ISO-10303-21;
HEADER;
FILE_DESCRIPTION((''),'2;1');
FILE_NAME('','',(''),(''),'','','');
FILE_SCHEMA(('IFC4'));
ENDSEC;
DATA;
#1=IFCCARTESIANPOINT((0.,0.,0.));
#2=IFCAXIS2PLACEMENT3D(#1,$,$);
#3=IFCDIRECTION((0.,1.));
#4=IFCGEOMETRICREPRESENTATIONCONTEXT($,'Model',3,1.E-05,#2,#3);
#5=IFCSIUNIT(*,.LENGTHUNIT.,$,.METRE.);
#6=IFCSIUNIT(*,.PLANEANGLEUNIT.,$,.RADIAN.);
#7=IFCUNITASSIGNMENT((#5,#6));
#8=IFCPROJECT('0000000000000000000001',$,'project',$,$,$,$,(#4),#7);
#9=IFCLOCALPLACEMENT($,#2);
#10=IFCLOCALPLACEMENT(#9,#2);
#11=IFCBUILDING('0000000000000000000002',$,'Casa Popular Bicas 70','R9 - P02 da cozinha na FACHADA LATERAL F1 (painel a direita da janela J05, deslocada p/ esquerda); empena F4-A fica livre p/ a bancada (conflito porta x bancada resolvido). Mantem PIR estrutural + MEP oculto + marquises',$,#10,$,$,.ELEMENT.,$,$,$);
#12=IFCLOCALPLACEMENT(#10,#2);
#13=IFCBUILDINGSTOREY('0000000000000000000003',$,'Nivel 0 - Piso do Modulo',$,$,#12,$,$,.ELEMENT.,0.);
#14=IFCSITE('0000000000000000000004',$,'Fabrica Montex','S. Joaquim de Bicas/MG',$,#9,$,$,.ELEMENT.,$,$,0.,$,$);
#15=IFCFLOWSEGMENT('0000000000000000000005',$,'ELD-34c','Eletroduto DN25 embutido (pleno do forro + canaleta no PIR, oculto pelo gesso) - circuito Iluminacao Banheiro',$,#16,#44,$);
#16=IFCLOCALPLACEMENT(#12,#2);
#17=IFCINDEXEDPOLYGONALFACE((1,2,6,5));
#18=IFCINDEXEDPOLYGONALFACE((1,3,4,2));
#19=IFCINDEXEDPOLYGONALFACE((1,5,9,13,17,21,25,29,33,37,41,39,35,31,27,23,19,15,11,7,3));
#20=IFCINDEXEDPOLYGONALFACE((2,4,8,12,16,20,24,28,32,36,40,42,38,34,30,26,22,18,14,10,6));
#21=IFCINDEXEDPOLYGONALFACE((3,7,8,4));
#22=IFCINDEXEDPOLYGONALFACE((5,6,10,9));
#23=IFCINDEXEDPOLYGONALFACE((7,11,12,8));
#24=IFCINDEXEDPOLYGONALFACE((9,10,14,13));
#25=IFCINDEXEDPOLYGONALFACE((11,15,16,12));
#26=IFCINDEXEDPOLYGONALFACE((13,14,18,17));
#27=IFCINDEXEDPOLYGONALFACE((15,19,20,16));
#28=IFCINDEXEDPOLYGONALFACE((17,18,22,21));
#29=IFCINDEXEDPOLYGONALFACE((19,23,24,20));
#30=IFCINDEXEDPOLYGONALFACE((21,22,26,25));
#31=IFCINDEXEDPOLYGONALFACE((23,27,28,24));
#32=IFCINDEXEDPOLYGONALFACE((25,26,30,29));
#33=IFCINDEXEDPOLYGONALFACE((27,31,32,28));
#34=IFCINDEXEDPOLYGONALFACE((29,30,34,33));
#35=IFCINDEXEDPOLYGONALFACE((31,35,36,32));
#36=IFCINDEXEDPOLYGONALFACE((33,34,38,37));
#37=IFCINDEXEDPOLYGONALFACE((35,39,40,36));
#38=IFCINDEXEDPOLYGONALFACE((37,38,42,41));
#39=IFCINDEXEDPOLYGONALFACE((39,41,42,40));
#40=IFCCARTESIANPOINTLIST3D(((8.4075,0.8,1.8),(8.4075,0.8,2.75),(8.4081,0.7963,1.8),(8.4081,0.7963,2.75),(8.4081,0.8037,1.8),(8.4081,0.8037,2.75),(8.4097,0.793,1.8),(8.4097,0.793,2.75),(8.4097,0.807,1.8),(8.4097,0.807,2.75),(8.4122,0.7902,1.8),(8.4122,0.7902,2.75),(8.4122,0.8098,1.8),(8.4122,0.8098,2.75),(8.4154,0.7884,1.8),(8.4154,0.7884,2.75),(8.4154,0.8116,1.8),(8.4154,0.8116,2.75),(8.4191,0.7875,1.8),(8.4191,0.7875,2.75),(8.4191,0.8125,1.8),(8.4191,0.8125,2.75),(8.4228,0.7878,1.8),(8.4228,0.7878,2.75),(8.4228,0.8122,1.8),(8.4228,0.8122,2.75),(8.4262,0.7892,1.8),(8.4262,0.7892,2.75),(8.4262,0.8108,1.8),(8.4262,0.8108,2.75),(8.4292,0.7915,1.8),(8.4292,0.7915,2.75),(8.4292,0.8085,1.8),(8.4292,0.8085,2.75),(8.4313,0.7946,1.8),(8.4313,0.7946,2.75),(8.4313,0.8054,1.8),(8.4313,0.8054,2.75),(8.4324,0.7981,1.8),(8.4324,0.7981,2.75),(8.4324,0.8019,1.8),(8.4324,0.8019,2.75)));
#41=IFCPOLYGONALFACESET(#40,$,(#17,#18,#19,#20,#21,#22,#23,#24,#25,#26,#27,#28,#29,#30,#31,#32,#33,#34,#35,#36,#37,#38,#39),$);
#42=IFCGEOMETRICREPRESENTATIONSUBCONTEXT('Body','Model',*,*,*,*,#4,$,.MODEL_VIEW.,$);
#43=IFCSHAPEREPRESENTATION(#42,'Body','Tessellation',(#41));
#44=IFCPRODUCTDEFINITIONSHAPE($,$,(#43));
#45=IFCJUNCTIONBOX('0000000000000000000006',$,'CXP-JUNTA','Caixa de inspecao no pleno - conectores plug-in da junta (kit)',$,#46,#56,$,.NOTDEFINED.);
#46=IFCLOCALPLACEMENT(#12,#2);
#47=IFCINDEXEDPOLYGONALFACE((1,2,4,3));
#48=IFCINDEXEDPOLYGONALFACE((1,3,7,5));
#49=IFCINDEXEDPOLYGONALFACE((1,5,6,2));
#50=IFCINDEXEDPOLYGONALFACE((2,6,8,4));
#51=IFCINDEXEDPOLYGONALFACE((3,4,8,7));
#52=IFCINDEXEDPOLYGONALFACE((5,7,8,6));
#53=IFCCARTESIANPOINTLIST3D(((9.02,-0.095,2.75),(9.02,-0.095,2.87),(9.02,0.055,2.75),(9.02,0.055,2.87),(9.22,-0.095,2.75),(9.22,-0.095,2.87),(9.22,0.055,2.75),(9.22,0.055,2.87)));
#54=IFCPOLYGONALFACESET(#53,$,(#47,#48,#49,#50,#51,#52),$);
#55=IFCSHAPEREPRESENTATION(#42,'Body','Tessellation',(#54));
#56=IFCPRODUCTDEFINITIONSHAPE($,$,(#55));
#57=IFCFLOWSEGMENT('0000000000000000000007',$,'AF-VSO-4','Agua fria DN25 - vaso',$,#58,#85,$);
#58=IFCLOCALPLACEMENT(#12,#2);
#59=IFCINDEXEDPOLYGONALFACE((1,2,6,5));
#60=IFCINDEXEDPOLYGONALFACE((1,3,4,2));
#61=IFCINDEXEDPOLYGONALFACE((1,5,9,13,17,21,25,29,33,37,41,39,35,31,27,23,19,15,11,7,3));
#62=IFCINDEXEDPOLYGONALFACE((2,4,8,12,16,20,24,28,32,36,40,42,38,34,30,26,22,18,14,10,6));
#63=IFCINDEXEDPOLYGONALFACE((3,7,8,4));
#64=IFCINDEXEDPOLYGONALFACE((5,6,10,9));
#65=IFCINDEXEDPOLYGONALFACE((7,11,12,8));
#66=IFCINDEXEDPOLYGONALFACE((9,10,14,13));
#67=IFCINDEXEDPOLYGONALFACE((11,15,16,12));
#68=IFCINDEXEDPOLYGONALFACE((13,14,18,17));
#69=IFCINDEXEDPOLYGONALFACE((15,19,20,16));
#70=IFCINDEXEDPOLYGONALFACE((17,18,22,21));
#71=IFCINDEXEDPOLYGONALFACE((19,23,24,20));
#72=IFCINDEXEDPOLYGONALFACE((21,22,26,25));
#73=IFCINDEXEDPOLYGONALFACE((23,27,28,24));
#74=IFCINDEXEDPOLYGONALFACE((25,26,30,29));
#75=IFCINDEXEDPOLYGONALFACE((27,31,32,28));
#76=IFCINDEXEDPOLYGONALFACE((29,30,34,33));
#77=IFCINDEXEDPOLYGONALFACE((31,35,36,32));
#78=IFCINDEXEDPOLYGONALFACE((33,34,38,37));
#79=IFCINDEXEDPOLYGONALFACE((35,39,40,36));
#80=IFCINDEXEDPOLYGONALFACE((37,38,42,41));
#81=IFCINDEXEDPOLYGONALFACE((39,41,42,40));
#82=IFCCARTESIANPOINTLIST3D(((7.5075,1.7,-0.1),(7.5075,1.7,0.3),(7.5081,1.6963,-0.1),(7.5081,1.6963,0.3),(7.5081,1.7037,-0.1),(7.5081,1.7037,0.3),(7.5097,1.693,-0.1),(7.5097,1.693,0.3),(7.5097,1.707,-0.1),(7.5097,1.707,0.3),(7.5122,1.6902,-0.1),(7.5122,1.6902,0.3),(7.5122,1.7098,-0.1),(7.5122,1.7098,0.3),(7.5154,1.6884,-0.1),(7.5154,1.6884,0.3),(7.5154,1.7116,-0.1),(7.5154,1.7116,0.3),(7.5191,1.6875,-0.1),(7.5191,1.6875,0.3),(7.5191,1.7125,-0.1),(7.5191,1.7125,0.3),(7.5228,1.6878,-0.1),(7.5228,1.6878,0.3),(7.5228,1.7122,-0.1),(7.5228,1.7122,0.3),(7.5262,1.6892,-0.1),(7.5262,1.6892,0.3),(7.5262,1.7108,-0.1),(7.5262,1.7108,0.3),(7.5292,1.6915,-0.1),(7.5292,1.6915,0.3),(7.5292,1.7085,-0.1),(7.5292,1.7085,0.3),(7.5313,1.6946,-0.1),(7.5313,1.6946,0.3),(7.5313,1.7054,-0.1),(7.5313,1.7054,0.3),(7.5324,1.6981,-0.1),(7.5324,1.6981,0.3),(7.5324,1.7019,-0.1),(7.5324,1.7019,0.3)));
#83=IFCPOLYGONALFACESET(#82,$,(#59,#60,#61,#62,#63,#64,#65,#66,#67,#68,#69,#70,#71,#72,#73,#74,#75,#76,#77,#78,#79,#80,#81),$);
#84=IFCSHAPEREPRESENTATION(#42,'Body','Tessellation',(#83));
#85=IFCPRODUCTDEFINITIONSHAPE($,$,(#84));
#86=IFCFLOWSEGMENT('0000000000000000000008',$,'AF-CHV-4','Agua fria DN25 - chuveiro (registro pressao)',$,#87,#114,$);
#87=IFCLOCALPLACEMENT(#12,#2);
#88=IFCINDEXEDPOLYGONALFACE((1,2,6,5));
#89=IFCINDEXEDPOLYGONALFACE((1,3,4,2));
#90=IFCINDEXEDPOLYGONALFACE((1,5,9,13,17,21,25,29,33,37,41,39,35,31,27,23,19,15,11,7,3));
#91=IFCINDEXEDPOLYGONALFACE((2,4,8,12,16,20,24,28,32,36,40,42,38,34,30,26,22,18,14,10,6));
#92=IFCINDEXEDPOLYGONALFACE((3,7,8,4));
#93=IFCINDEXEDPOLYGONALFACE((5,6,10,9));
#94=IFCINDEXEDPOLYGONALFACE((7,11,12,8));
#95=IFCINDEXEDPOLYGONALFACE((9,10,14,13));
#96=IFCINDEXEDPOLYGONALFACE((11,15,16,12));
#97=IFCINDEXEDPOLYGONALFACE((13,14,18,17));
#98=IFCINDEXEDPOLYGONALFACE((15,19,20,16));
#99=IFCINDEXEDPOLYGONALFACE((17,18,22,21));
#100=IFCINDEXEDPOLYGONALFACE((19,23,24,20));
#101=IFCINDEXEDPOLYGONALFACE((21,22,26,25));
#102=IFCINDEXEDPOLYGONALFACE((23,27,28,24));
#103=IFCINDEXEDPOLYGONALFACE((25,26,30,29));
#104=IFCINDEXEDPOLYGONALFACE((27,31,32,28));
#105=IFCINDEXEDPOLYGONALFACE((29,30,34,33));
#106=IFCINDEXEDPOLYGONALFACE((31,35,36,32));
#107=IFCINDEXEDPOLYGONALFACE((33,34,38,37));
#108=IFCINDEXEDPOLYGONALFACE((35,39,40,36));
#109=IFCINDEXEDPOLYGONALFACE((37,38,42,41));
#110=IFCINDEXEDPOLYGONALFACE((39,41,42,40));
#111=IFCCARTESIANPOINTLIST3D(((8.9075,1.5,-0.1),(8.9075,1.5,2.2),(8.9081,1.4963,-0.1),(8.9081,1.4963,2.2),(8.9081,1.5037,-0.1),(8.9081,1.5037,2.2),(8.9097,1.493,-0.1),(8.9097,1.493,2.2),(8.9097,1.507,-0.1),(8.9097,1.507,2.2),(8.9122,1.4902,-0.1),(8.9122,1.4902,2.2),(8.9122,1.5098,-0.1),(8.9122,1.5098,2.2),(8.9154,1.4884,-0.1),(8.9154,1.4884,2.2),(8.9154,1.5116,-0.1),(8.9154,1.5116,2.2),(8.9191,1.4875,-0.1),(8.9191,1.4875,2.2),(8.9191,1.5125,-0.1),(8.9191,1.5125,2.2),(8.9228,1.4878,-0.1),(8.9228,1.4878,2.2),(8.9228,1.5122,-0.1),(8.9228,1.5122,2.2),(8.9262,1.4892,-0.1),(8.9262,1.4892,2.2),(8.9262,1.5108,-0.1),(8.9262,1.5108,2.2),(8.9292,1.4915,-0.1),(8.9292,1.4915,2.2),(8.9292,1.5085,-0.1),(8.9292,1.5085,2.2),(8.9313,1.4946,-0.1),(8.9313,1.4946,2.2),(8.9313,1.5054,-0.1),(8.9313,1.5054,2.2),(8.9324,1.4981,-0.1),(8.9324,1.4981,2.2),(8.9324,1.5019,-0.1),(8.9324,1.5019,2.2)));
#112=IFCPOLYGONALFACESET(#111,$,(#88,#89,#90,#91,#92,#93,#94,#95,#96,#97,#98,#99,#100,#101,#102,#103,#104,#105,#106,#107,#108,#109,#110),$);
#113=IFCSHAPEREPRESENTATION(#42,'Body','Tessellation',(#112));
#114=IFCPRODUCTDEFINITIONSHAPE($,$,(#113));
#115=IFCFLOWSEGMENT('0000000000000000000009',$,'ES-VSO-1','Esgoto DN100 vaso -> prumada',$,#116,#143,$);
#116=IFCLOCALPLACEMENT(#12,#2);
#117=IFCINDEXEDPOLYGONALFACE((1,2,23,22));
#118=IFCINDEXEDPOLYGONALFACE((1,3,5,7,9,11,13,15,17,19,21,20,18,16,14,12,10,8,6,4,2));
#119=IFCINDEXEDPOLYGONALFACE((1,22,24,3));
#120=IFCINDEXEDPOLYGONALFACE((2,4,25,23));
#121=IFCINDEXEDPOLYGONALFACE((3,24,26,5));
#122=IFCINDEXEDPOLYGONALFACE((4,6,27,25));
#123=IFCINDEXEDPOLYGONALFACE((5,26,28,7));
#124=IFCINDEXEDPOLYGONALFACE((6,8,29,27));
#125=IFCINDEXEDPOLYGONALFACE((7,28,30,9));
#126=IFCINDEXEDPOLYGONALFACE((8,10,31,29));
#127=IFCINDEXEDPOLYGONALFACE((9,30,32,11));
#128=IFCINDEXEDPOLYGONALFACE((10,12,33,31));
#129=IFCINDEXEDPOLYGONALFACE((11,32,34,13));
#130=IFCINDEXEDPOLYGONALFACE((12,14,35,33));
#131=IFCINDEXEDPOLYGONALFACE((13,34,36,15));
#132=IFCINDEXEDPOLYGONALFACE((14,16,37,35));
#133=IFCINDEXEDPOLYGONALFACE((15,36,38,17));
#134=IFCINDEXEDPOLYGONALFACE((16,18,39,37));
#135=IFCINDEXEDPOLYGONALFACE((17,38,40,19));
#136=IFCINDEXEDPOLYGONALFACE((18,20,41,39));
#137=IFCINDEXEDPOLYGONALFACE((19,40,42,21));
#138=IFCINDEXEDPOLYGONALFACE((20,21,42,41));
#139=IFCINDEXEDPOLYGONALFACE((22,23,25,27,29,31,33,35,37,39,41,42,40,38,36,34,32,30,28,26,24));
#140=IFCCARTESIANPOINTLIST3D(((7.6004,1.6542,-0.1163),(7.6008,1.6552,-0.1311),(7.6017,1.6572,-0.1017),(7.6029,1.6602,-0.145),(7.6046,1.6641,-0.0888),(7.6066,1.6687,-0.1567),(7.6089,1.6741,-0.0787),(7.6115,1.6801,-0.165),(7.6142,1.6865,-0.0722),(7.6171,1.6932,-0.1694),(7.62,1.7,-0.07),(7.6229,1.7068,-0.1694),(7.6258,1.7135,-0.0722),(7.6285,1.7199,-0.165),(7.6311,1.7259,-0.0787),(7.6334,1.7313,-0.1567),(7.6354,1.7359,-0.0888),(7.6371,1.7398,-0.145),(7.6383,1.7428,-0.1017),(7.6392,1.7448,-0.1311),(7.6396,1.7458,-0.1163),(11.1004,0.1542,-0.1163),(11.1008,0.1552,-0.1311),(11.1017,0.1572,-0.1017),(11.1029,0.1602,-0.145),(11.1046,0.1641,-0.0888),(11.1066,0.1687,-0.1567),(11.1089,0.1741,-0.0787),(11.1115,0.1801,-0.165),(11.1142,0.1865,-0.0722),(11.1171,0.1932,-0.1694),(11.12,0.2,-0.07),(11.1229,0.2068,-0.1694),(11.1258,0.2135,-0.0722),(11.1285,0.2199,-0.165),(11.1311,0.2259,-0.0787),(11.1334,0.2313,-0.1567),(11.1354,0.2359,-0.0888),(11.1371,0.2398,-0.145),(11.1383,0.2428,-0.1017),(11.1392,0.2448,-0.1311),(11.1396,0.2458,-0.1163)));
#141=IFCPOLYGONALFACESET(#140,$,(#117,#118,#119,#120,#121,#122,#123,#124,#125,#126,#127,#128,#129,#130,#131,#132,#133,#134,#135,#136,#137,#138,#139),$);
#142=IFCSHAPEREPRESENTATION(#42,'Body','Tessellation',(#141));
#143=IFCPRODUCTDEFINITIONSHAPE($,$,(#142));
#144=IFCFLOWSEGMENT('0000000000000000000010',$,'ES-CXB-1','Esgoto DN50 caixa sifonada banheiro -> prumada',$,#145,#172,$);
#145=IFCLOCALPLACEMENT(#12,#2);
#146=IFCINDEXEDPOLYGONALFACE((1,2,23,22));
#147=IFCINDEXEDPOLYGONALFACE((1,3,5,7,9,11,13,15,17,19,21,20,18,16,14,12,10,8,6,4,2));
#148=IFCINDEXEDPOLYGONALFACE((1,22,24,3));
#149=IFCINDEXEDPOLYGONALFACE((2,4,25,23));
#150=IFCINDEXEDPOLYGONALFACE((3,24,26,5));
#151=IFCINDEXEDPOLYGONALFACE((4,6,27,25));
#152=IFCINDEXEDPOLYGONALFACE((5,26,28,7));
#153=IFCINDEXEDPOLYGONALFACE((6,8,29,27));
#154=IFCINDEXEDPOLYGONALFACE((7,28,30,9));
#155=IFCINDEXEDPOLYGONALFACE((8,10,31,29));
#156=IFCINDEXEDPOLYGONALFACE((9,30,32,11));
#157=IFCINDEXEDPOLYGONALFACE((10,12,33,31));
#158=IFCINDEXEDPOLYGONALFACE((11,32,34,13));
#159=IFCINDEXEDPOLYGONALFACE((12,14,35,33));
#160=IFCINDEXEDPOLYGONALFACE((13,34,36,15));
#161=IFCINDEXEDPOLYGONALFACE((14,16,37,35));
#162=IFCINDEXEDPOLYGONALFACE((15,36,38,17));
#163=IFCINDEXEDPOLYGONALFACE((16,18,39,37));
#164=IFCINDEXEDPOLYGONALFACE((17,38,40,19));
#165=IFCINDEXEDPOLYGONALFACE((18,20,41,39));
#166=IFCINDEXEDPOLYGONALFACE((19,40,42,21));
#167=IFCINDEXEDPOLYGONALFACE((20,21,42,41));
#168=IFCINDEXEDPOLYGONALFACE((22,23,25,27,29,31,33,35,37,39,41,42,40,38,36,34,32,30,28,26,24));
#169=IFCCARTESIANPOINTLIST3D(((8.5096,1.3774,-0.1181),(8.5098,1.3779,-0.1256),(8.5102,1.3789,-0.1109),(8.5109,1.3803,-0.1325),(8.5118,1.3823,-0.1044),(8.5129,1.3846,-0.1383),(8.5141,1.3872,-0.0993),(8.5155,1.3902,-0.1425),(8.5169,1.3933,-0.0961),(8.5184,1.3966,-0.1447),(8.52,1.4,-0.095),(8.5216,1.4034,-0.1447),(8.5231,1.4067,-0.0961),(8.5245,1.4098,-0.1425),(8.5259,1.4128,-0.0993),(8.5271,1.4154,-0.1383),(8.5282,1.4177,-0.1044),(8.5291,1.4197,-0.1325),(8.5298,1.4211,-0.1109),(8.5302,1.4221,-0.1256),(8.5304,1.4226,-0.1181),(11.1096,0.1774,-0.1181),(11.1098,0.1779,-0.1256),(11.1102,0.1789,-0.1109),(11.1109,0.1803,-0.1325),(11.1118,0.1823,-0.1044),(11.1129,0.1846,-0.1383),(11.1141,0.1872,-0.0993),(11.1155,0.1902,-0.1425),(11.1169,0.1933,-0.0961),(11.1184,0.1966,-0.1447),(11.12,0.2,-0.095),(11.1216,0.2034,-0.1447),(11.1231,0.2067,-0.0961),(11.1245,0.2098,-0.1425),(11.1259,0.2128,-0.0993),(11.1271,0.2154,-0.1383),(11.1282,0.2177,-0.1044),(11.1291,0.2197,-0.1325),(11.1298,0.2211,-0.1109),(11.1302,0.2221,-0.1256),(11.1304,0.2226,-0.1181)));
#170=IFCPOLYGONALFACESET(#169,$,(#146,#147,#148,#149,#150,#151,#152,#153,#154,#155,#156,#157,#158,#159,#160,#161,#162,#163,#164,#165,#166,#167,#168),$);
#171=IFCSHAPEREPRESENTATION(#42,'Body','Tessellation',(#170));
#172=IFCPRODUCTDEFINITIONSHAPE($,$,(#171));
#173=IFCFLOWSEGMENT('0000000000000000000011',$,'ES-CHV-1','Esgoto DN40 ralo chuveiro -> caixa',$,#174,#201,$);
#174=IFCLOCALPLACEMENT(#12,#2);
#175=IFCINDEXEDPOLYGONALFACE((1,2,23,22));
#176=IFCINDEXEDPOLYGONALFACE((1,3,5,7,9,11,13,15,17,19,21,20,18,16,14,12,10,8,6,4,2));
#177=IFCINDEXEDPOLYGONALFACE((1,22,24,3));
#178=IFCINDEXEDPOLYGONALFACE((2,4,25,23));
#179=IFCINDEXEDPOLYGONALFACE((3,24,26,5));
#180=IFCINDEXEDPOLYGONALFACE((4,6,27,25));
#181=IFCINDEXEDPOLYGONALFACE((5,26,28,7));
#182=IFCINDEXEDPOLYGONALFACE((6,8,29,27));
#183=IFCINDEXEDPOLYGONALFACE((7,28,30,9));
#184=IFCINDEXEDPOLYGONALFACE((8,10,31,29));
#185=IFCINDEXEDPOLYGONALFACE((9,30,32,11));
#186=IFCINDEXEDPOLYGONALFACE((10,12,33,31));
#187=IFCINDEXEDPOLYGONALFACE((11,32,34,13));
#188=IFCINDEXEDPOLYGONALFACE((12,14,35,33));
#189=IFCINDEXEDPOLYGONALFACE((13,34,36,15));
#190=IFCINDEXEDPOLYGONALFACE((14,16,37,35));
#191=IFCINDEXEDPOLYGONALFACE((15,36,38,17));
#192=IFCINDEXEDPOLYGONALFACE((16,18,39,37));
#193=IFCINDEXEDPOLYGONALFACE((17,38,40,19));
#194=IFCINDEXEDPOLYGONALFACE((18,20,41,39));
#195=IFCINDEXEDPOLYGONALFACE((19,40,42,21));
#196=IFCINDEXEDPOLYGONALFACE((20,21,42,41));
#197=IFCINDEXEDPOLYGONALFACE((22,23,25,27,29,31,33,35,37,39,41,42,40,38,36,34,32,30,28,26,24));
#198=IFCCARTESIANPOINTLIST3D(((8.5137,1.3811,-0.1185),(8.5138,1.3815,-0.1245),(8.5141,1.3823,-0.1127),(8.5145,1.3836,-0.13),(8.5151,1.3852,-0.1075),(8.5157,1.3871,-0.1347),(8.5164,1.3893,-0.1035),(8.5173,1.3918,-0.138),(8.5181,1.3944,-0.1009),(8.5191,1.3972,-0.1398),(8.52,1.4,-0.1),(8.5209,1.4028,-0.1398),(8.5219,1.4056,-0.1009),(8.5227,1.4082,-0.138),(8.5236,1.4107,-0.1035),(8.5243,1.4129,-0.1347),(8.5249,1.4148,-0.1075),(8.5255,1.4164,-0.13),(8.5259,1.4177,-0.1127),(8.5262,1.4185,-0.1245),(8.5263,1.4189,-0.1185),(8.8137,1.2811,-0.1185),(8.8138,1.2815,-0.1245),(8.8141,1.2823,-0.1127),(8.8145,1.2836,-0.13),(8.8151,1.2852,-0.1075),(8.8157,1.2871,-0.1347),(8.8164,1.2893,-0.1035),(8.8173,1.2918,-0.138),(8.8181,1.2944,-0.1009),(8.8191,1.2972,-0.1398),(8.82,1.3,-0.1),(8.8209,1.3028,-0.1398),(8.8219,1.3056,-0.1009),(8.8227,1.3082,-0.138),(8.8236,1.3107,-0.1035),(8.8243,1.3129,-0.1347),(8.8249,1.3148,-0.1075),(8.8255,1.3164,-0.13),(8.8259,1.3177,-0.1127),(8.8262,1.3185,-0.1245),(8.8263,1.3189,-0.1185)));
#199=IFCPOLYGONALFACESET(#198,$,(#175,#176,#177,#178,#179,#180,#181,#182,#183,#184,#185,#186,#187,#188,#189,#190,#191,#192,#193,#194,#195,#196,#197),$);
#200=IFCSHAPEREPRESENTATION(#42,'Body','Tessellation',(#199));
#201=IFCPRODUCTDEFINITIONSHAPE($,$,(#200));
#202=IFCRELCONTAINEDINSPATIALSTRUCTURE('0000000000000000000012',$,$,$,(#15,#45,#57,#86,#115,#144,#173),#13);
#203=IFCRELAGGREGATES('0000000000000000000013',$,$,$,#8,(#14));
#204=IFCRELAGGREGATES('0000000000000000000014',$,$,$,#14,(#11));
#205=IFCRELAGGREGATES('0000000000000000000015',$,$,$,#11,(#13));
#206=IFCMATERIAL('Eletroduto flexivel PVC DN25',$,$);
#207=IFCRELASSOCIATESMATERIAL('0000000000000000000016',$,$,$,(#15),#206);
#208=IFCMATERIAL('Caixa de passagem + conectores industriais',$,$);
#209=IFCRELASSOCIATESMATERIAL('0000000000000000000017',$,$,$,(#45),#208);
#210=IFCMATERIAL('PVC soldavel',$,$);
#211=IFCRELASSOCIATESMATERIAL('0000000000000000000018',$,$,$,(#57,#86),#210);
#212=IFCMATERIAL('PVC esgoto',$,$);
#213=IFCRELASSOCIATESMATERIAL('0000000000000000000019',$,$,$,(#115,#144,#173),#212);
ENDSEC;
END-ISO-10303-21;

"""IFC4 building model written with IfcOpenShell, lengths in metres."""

from ifc_helpers import new_model, si_unit, direction, frame, frame_2d, origin, origin_2d, place, context, subcontext, project, spatial, rectangle, circle, extrude, material, element, save


model = new_model("IFC4")

# Units and contexts
model_context = context("Model", 3, precision=1e-05, world=origin(), true_north=direction((0.0, 1.0)))
body_context = subcontext(model_context, "Body", "Model", "MODEL_VIEW")
ifc_project = project(units=[si_unit("LENGTHUNIT", "METRE"), si_unit("PLANEANGLEUNIT", "RADIAN")], contexts=[model_context])

# Site, building, storey
site_placement = place(None, origin())
site = spatial("IfcSite", under=ifc_project, at=site_placement, Name="Fabrica Montex", Description="S. Joaquim de Bicas/MG", CompositionType="ELEMENT", RefElevation=0.0)
building_placement = place(site_placement, origin())
building = spatial("IfcBuilding", under=site, at=building_placement, Name="Casa Popular Bicas 70", Description="R9 - P02 da cozinha na FACHADA LATERAL F1 (painel a direita da janela J05, deslocada p/ esquerda); empena F4-A fica livre p/ a bancada (conflito porta x bancada resolvido). Mantem PIR estrutural + MEP oculto + marquises", CompositionType="ELEMENT")
storey_placement = place(building_placement, origin())
storey = spatial("IfcBuildingStorey", under=building, at=storey_placement, Name="Nivel 0 - Piso do Modulo", CompositionType="ELEMENT", Elevation=0.0)

# Shared definitions
ifc_material_1 = material(Name="Eletroduto flexivel PVC DN25")

# Flow segment
flow_segment_1_placement = place(None, frame((8.42, 0.8, 2.75), z_axis=(0.0, 0.0, -1.0), x_axis=(-1.0, 0.0, 0.0)))
element("IfcFlowSegment", 1, at=flow_segment_1_placement, inside=storey, material=ifc_material_1, Name="ELD-34c", Description="Eletroduto DN25 embutido (pleno do forro + canaleta no PIR, oculto pelo gesso) - circuito Iluminacao Banheiro", context=body_context, shape_type="SweptSolid", body=[
    extrude(circle(Radius=0.0125, at=origin_2d()), origin(), (0.0, 0.0, 1.0), 0.95),
])

# Junction box
ifc_material_2 = material(Name="Caixa de passagem + conectores industriais")
junction_box_placement = place(None, frame((9.22, 0.055, 2.75), z_axis=(0.0, 0.0, 1.0), x_axis=(-1.0, 0.0, 0.0)))
element("IfcJunctionBox", 2, at=junction_box_placement, inside=storey, material=ifc_material_2, Name="CXP-JUNTA", Description="Caixa de inspecao no pleno - conectores plug-in da junta (kit)", PredefinedType="NOTDEFINED", context=body_context, shape_type="SweptSolid", body=[
    extrude(rectangle(XDim=0.2, YDim=0.15, at=frame_2d((0.1, 0.075))), origin(), (0.0, 0.0, 1.0), 0.12),
])

# Flow segments
ifc_material_3 = material(Name="PVC soldavel")
flow_segment_2_placement = place(None, frame((7.52, 1.7, -0.1), z_axis=(0.0, 0.0, 1.0), x_axis=(-1.0, 0.0, 0.0)))
element("IfcFlowSegment", 3, at=flow_segment_2_placement, inside=storey, material=ifc_material_3, Name="AF-VSO-4", Description="Agua fria DN25 - vaso", context=body_context, shape_type="SweptSolid", body=[
    extrude(circle(Radius=0.0125, at=origin_2d()), origin(), (0.0, 0.0, 1.0), 0.4),
])
flow_segment_3_placement = place(None, frame((8.92, 1.5, -0.1), z_axis=(0.0, 0.0, 1.0), x_axis=(-1.0, 0.0, 0.0)))
element("IfcFlowSegment", 4, at=flow_segment_3_placement, inside=storey, material=ifc_material_3, Name="AF-CHV-4", Description="Agua fria DN25 - chuveiro (registro pressao)", context=body_context, shape_type="SweptSolid", body=[
    extrude(circle(Radius=0.0125, at=origin_2d()), origin(), (0.0, 0.0, 1.0), 2.3),
])
ifc_material_4 = material(Name="PVC esgoto")
flow_segment_4_placement = place(None, frame((7.62, 1.7, -0.12), z_axis=(0.919145, -0.393919, 0.0), x_axis=(0.0, 0.0, 1.0)))
element("IfcFlowSegment", 5, at=flow_segment_4_placement, inside=storey, material=ifc_material_4, Name="ES-VSO-1", Description="Esgoto DN100 vaso -> prumada", context=body_context, shape_type="SweptSolid", body=[
    extrude(circle(Radius=0.05, at=origin_2d()), origin(), (0.0, 0.0, 1.0), 3.8079),
])
flow_segment_5_placement = place(None, frame((8.52, 1.4, -0.12), z_axis=(0.907959, -0.419058, 0.0), x_axis=(0.0, 0.0, 1.0)))
element("IfcFlowSegment", 6, at=flow_segment_5_placement, inside=storey, material=ifc_material_4, Name="ES-CXB-1", Description="Esgoto DN50 caixa sifonada banheiro -> prumada", context=body_context, shape_type="SweptSolid", body=[
    extrude(circle(Radius=0.025, at=origin_2d()), origin(), (0.0, 0.0, 1.0), 2.8636),
])
flow_segment_6_placement = place(None, frame((8.82, 1.3, -0.12), z_axis=(-0.948683, 0.316228, 0.0), x_axis=(0.0, 0.0, 1.0)))
element("IfcFlowSegment", 7, at=flow_segment_6_placement, inside=storey, material=ifc_material_4, Name="ES-CHV-1", Description="Esgoto DN40 ralo chuveiro -> caixa", context=body_context, shape_type="SweptSolid", body=[
    extrude(circle(Radius=0.02, at=origin_2d()), origin(), (0.0, 0.0, 1.0), 0.3162),
])

save(model, "model.ifc")
